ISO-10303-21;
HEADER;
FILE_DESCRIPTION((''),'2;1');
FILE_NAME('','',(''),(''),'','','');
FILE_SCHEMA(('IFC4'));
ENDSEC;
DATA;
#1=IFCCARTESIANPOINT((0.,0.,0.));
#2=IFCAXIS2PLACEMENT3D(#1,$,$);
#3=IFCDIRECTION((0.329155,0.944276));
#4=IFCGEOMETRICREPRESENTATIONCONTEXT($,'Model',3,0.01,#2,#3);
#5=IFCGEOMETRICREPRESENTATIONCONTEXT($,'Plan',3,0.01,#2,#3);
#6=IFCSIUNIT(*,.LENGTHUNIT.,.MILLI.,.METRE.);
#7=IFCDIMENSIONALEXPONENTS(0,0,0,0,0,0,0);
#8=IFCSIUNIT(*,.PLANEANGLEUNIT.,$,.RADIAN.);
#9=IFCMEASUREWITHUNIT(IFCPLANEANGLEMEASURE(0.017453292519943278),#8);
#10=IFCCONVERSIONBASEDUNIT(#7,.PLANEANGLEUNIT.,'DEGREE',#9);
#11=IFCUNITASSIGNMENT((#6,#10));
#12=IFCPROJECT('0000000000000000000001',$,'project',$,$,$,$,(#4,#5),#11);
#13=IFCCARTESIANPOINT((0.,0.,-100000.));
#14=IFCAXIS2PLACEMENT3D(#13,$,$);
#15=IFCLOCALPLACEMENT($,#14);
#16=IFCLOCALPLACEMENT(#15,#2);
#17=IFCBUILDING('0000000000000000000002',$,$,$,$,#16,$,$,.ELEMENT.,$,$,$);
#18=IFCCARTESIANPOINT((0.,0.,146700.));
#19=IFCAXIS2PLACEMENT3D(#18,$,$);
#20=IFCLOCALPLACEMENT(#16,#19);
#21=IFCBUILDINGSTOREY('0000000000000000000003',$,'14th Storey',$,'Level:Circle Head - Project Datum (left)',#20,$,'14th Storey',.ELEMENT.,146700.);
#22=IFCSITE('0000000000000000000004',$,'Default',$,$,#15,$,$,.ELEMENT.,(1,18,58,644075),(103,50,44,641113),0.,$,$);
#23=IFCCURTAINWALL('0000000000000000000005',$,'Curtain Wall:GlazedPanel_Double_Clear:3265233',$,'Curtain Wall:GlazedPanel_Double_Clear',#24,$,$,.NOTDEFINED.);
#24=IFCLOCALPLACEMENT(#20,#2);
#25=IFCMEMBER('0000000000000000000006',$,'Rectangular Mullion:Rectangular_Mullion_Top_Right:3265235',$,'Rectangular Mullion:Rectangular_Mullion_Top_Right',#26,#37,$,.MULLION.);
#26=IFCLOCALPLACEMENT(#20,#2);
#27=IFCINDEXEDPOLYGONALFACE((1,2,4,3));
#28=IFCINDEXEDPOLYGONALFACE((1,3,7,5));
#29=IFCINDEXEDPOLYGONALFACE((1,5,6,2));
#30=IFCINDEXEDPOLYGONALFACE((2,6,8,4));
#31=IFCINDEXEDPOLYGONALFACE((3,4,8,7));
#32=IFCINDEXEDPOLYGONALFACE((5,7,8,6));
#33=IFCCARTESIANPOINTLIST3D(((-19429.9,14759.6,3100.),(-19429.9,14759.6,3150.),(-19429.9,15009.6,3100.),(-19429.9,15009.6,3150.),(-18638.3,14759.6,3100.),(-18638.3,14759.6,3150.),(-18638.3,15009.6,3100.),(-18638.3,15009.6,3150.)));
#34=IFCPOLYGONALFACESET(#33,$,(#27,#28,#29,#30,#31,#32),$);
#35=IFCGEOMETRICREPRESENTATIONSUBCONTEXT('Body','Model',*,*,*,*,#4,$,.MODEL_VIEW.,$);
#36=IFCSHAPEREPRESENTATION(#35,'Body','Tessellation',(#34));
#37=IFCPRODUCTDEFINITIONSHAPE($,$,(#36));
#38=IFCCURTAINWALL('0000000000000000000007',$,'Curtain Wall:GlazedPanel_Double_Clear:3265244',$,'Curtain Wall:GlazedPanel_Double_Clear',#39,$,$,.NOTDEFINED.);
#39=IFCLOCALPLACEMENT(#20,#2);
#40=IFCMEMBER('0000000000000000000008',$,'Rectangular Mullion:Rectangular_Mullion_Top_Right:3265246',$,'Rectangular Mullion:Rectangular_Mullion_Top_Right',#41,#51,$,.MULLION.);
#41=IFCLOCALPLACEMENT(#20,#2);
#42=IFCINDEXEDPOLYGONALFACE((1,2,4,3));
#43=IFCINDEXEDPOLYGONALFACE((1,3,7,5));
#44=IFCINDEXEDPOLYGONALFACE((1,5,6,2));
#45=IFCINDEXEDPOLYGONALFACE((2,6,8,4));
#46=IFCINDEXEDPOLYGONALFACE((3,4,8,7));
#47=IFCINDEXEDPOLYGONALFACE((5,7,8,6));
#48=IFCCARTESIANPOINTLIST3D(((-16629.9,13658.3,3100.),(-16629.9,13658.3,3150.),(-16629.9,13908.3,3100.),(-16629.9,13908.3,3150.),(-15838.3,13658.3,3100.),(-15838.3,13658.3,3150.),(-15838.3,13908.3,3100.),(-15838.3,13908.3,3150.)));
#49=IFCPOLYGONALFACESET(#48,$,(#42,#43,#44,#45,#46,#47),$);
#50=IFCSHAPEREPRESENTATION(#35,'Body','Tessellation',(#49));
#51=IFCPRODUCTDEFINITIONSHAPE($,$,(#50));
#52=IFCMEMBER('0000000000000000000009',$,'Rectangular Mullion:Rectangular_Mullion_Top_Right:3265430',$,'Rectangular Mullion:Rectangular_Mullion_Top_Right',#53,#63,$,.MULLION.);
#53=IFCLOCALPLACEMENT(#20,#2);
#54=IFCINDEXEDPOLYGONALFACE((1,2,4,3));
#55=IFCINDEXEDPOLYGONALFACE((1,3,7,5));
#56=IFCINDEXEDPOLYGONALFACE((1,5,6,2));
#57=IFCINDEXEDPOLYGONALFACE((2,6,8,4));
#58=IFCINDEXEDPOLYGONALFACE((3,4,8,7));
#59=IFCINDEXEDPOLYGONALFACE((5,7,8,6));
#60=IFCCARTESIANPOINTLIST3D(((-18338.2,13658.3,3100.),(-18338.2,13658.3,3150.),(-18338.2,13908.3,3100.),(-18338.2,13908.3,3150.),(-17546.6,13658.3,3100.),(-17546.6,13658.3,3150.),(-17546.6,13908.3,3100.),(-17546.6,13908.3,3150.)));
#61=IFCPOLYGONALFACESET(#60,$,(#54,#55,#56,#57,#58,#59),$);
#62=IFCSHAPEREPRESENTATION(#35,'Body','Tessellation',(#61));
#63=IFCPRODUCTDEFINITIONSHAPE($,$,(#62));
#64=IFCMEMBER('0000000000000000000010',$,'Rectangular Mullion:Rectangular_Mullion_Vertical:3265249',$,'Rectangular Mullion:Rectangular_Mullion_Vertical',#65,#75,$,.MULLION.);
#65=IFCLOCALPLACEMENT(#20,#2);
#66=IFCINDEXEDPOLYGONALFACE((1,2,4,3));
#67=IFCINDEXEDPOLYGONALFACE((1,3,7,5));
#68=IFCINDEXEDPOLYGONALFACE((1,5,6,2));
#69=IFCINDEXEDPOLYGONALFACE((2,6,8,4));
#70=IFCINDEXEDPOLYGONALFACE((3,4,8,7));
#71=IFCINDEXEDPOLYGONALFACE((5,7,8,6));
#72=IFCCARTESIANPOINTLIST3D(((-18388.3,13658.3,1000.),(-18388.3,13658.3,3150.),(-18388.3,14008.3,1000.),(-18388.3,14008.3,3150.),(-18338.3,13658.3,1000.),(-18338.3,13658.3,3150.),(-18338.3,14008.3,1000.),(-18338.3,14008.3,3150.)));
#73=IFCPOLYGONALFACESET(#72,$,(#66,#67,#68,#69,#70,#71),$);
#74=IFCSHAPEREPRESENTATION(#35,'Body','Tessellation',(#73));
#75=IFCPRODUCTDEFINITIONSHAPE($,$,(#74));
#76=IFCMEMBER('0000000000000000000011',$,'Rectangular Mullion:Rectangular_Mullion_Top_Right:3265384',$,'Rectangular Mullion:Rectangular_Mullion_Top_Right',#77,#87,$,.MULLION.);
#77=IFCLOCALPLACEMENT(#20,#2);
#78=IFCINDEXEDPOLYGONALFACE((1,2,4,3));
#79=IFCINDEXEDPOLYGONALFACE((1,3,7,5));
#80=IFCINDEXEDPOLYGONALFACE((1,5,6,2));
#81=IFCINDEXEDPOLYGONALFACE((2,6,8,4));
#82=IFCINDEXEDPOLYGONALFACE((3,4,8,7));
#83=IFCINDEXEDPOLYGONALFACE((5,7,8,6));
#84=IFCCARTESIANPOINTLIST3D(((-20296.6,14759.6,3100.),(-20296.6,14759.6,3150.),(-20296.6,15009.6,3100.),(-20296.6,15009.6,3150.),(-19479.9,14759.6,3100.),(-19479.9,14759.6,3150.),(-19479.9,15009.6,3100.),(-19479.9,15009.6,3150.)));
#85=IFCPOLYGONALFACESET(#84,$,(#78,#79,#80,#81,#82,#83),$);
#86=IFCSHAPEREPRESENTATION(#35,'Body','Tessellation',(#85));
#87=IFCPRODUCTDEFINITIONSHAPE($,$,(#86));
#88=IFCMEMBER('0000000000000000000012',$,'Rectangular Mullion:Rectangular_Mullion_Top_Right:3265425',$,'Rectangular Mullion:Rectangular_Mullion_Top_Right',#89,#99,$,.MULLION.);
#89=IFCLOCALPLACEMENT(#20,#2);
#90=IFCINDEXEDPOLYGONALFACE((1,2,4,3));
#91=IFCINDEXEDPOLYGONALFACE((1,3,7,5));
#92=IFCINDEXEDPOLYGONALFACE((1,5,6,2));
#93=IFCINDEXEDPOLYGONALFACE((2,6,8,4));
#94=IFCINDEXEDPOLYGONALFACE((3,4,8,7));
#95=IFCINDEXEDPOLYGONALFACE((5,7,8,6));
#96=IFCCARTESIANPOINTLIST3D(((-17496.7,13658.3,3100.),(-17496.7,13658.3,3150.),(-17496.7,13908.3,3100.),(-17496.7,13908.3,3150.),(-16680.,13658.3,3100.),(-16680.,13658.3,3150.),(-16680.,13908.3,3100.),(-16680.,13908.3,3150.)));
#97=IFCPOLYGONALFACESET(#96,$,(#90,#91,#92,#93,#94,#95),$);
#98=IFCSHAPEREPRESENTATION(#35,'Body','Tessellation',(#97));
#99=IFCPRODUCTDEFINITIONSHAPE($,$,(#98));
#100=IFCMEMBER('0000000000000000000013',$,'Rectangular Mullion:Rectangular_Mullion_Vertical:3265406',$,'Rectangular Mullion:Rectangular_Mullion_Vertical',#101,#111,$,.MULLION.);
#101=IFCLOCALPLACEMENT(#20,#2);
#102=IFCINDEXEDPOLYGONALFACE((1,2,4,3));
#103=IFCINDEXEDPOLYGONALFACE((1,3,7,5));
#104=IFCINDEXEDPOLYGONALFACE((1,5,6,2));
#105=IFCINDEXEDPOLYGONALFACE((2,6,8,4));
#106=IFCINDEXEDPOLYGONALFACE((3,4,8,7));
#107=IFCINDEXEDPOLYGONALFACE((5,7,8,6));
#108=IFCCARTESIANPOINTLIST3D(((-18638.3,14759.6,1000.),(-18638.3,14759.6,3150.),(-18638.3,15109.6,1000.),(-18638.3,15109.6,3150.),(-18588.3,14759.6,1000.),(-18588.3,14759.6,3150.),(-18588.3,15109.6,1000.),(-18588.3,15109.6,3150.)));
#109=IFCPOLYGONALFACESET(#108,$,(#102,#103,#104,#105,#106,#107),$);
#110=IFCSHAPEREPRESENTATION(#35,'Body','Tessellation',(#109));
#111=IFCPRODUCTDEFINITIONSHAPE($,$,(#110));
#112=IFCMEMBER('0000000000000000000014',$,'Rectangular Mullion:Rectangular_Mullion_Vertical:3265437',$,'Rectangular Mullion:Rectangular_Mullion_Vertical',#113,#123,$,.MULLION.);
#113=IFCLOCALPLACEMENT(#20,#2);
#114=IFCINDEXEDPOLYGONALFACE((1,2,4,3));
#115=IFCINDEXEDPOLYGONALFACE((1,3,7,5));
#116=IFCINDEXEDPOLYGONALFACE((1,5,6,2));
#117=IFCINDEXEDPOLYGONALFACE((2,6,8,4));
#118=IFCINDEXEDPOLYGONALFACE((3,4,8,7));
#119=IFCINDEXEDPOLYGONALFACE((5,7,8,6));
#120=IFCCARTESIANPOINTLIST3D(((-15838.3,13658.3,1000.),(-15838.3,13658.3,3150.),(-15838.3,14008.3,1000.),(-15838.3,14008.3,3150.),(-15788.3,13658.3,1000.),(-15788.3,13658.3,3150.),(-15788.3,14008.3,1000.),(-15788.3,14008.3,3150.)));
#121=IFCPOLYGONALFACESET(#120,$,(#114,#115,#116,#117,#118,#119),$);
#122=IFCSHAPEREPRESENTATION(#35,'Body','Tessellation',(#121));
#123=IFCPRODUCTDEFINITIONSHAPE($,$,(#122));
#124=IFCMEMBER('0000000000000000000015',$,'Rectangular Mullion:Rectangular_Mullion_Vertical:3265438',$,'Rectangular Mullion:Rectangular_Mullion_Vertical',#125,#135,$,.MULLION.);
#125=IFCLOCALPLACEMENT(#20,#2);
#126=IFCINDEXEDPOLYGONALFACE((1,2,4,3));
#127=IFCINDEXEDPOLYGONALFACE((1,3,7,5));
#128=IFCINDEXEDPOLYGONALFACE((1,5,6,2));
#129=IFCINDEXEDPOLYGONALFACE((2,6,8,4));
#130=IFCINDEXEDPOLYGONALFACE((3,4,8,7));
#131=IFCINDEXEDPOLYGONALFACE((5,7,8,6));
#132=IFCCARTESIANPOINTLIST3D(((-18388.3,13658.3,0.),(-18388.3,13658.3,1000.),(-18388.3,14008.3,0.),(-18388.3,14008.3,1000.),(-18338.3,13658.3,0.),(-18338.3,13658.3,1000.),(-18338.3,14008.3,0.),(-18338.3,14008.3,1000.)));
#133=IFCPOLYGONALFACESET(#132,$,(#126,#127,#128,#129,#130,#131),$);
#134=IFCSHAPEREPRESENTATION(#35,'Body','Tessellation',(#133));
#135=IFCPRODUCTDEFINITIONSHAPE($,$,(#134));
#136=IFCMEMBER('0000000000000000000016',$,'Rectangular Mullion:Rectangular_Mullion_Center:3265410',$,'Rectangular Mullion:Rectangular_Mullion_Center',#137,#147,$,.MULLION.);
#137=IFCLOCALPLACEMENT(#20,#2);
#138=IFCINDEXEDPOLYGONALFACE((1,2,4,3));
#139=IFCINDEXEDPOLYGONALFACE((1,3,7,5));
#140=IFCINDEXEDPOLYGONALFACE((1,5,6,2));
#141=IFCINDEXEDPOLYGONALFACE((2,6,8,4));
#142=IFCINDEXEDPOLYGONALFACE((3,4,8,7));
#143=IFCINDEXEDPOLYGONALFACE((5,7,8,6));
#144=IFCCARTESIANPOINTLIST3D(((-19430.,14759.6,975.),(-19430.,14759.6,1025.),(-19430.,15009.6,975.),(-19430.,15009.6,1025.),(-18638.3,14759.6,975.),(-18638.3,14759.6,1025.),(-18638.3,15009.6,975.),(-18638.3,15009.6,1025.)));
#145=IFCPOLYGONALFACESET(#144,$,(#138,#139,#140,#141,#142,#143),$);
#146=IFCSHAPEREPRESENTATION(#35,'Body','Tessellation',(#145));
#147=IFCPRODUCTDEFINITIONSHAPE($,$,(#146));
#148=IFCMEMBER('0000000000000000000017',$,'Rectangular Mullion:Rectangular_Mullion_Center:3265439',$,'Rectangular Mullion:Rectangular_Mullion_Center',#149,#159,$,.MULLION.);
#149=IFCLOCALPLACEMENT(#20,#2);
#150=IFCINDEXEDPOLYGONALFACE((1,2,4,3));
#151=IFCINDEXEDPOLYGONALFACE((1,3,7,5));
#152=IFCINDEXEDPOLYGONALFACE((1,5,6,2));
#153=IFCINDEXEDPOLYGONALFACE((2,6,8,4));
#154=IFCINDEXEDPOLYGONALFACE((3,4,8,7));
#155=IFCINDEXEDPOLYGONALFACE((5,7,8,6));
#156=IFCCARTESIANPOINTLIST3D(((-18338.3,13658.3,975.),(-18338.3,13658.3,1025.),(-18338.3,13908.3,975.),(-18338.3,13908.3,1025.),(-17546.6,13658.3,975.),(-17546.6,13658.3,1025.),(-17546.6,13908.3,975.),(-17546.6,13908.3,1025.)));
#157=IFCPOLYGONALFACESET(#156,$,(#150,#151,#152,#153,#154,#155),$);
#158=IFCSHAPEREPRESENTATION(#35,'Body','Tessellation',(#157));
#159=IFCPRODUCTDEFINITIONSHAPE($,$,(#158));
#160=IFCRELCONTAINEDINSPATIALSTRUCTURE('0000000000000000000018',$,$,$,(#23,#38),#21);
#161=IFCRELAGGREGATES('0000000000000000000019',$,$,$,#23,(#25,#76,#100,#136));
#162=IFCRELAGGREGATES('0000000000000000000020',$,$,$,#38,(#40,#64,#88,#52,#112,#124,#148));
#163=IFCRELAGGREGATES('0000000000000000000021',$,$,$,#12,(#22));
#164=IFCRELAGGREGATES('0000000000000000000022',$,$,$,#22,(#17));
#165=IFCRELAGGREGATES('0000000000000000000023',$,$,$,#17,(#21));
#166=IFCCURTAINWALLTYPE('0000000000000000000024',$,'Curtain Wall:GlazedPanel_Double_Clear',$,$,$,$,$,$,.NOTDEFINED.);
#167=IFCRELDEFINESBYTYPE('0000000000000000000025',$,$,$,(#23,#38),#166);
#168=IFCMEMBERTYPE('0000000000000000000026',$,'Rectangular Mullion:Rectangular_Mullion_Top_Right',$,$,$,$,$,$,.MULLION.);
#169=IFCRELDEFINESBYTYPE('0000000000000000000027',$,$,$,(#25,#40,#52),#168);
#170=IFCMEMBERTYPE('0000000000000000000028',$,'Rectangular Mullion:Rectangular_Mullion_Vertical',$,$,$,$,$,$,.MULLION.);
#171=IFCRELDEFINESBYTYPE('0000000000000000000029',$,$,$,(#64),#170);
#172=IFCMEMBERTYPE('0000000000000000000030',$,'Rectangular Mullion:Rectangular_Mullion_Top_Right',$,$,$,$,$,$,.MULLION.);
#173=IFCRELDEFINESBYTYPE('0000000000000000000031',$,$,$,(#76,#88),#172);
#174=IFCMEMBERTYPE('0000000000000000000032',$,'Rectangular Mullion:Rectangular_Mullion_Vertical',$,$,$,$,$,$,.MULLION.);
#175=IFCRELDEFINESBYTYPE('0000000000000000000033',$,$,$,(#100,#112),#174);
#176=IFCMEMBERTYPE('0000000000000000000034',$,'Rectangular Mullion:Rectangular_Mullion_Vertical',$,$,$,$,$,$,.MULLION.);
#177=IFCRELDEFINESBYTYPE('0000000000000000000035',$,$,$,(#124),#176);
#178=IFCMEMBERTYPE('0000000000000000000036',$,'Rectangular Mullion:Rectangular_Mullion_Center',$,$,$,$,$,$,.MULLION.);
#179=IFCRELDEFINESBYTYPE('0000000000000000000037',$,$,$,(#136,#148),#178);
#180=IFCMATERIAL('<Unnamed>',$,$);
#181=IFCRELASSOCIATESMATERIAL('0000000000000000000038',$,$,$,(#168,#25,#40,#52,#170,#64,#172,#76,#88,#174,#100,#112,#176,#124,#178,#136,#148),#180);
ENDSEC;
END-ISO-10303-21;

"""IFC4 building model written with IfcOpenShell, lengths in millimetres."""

from ifc_helpers import new_model, entity, si_unit, converted_unit, direction, frame, origin, place, context, subcontext, project, spatial, indexed_curve, outline, extrude, source, transform, mapped, material, type_object, type_shapes, element, aggregate, save


model = new_model("IFC4")

# Units and contexts
model_context = context("Model", 3, precision=0.01, world=origin(), true_north=direction((0.329155, 0.944276)))
plan_context = context("Plan", 3, precision=0.01, world=origin(), true_north=direction((0.329155, 0.944276)))
body_context = subcontext(model_context, "Body", "Model", "MODEL_VIEW")
ifc_project = project(units=[si_unit("LENGTHUNIT", "METRE", prefix="MILLI"), converted_unit("PLANEANGLEUNIT", "DEGREE", entity("IfcPlaneAngleMeasure", 0.017453292519943278), si_unit("PLANEANGLEUNIT", "RADIAN"), dimensions=[0, 0, 0, 0, 0, 0, 0])], contexts=[model_context, plan_context])

# Site, building, storey
site_placement = place(None, frame((0.0, 0.0, -100000.0)))
site = spatial("IfcSite", under=ifc_project, at=site_placement, Name="Default", CompositionType="ELEMENT", RefLatitude=(1, 18, 58, 644075), RefLongitude=(103, 50, 44, 641113), RefElevation=0.0)
building_placement = place(site_placement, origin())
building = spatial("IfcBuilding", under=site, at=building_placement, CompositionType="ELEMENT")
storey_placement = place(building_placement, frame((0.0, 0.0, 146700.0)))
storey = spatial("IfcBuildingStorey", under=building, at=storey_placement, Name="14th Storey", ObjectType="Level:Circle Head - Project Datum (left)", LongName="14th Storey", CompositionType="ELEMENT", Elevation=146700.0)

# Curtain wall, member
curtain_wall_type = type_object("IfcCurtainWallType", Name="Curtain Wall:GlazedPanel_Double_Clear", PredefinedType="NOTDEFINED")
curtain_wall_1_placement = place(storey_placement, frame((0.0, 0.0, -146700.0)))
curtain_wall_1 = element("IfcCurtainWall", 1, at=curtain_wall_1_placement, inside=storey, type_object=curtain_wall_type, Name="Curtain Wall:GlazedPanel_Double_Clear:3265233", ObjectType="Curtain Wall:GlazedPanel_Double_Clear", PredefinedType="NOTDEFINED")
ifc_material_1 = material(Name="<Unnamed>")
member_type_1 = type_object("IfcMemberType", Name="Rectangular Mullion:Rectangular_Mullion_Top_Right", PredefinedType="MULLION", material=ifc_material_1)
shared_shape_1 = source(origin(), body_context, "Body", "SweptSolid", [
    extrude(outline(indexed_curve([(-25.0, -125.0), (25.0, -125.0), (25.0, 125.0), (-25.0, 125.0), (-25.0, -125.0)], self_intersect=False)), frame((-25.0, 0.0, -791.6), z_axis=(0.0, 0.0, 1.0), x_axis=(-1.0, 0.0, 0.0)), (0.0, 0.0, 1.0), 791.6),
])
type_shapes(member_type_1, [shared_shape_1])
member_1_placement = place(curtain_wall_1_placement, frame((-18638.3, 14884.6, 149850.0), z_axis=(1.0, 0.0, 0.0), x_axis=(0.0, 0.0, 1.0)))
member_1 = element("IfcMember", 2, at=member_1_placement, type_object=member_type_1, material=ifc_material_1, Name="Rectangular Mullion:Rectangular_Mullion_Top_Right:3265235", ObjectType="Rectangular Mullion:Rectangular_Mullion_Top_Right", PredefinedType="MULLION", context=body_context, shape_type="MappedRepresentation", body=[
    mapped(shared_shape_1, transform((0.0, 0.0, 0.0), scale=1.0)),
])

# Curtain wall, members
curtain_wall_2_placement = place(storey_placement, frame((0.0, 0.0, -146700.0)))
curtain_wall_2 = element("IfcCurtainWall", 3, at=curtain_wall_2_placement, inside=storey, type_object=curtain_wall_type, Name="Curtain Wall:GlazedPanel_Double_Clear:3265244", ObjectType="Curtain Wall:GlazedPanel_Double_Clear", PredefinedType="NOTDEFINED")
member_2_placement = place(curtain_wall_2_placement, frame((-15838.3, 13783.3, 149850.0), z_axis=(1.0, 0.0, 0.0), x_axis=(0.0, 0.0, 1.0)))
member_2 = element("IfcMember", 4, at=member_2_placement, type_object=member_type_1, material=ifc_material_1, Name="Rectangular Mullion:Rectangular_Mullion_Top_Right:3265246", ObjectType="Rectangular Mullion:Rectangular_Mullion_Top_Right", PredefinedType="MULLION", context=body_context, shape_type="MappedRepresentation", body=[
    mapped(shared_shape_1, transform((0.0, 0.0, 0.0), scale=1.0)),
])
member_3_placement = place(curtain_wall_2_placement, frame((-17546.6, 13783.3, 149850.0), z_axis=(1.0, 0.0, 0.0), x_axis=(0.0, 0.0, 1.0)))
member_3 = element("IfcMember", 5, at=member_3_placement, type_object=member_type_1, material=ifc_material_1, Name="Rectangular Mullion:Rectangular_Mullion_Top_Right:3265430", ObjectType="Rectangular Mullion:Rectangular_Mullion_Top_Right", PredefinedType="MULLION", context=body_context, shape_type="MappedRepresentation", body=[
    mapped(shared_shape_1, transform((0.0, 0.0, 0.0), scale=1.0)),
])
member_type_2 = type_object("IfcMemberType", Name="Rectangular Mullion:Rectangular_Mullion_Vertical", PredefinedType="MULLION", material=ifc_material_1)
shared_shape_2 = source(origin(), body_context, "Body", "SweptSolid", [
    extrude(outline(indexed_curve([(-25.0, -175.0), (25.0, -175.0), (25.0, 175.0), (-25.0, 175.0), (-25.0, -175.0)], self_intersect=False)), frame((-25.0, -50.0, -2150.0), z_axis=(0.0, 0.0, 1.0), x_axis=(-1.0, 0.0, 0.0)), (0.0, 0.0, 1.0), 2150.0),
])
type_shapes(member_type_2, [shared_shape_2])
member_4_placement = place(curtain_wall_2_placement, frame((-18388.3, 13783.3, 149850.0), z_axis=(0.0, 0.0, 1.0), x_axis=(-1.0, 0.0, 0.0)))
member_4 = element("IfcMember", 6, at=member_4_placement, type_object=member_type_2, material=ifc_material_1, Name="Rectangular Mullion:Rectangular_Mullion_Vertical:3265249", ObjectType="Rectangular Mullion:Rectangular_Mullion_Vertical", PredefinedType="MULLION", context=body_context, shape_type="MappedRepresentation", body=[
    mapped(shared_shape_2, transform((0.0, 0.0, 0.0), scale=1.0)),
])

# Members
member_type_3 = type_object("IfcMemberType", Name="Rectangular Mullion:Rectangular_Mullion_Top_Right", PredefinedType="MULLION", material=ifc_material_1)
shared_shape_3 = source(origin(), body_context, "Body", "SweptSolid", [
    extrude(outline(indexed_curve([(-25.0, -125.0), (25.0, -125.0), (25.0, 125.0), (-25.0, 125.0), (-25.0, -125.0)], self_intersect=False)), frame((-25.0, 0.0, -816.7), z_axis=(0.0, 0.0, 1.0), x_axis=(-1.0, 0.0, 0.0)), (0.0, 0.0, 1.0), 816.7),
])
type_shapes(member_type_3, [shared_shape_3])
member_5_placement = place(curtain_wall_1_placement, frame((-19479.9, 14884.6, 149850.0), z_axis=(1.0, 0.0, 0.0), x_axis=(0.0, 0.0, 1.0)))
member_5 = element("IfcMember", 7, at=member_5_placement, type_object=member_type_3, material=ifc_material_1, Name="Rectangular Mullion:Rectangular_Mullion_Top_Right:3265384", ObjectType="Rectangular Mullion:Rectangular_Mullion_Top_Right", PredefinedType="MULLION", context=body_context, shape_type="MappedRepresentation", body=[
    mapped(shared_shape_3, transform((0.0, 0.0, 0.0), scale=1.0)),
])
member_6_placement = place(curtain_wall_2_placement, frame((-16680.0, 13783.3, 149850.0), z_axis=(1.0, 0.0, 0.0), x_axis=(0.0, 0.0, 1.0)))
member_6 = element("IfcMember", 8, at=member_6_placement, type_object=member_type_3, material=ifc_material_1, Name="Rectangular Mullion:Rectangular_Mullion_Top_Right:3265425", ObjectType="Rectangular Mullion:Rectangular_Mullion_Top_Right", PredefinedType="MULLION", context=body_context, shape_type="MappedRepresentation", body=[
    mapped(shared_shape_3, transform((0.0, 0.0, 0.0), scale=1.0)),
])
member_type_4 = type_object("IfcMemberType", Name="Rectangular Mullion:Rectangular_Mullion_Vertical", PredefinedType="MULLION", material=ifc_material_1)
shared_shape_4 = source(origin(), body_context, "Body", "SweptSolid", [
    extrude(outline(indexed_curve([(-25.0, -175.0), (25.0, -175.0), (25.0, 175.0), (-25.0, 175.0), (-25.0, -175.0)], self_intersect=False)), frame((-25.0, -50.0, -2150.0), z_axis=(0.0, 0.0, 1.0), x_axis=(-1.0, 0.0, 0.0)), (0.0, 0.0, 1.0), 2150.0),
])
type_shapes(member_type_4, [shared_shape_4])
member_7_placement = place(curtain_wall_1_placement, frame((-18588.3, 14884.6, 147700.0), z_axis=(0.0, 0.0, -1.0), x_axis=(1.0, 0.0, 0.0)))
member_7 = element("IfcMember", 9, at=member_7_placement, type_object=member_type_4, material=ifc_material_1, Name="Rectangular Mullion:Rectangular_Mullion_Vertical:3265406", ObjectType="Rectangular Mullion:Rectangular_Mullion_Vertical", PredefinedType="MULLION", context=body_context, shape_type="MappedRepresentation", body=[
    mapped(shared_shape_4, transform((0.0, 0.0, 0.0), scale=1.0)),
])
member_8_placement = place(curtain_wall_2_placement, frame((-15788.3, 13783.3, 147700.0), z_axis=(0.0, 0.0, -1.0), x_axis=(1.0, 0.0, 0.0)))
member_8 = element("IfcMember", 10, at=member_8_placement, type_object=member_type_4, material=ifc_material_1, Name="Rectangular Mullion:Rectangular_Mullion_Vertical:3265437", ObjectType="Rectangular Mullion:Rectangular_Mullion_Vertical", PredefinedType="MULLION", context=body_context, shape_type="MappedRepresentation", body=[
    mapped(shared_shape_4, transform((0.0, 0.0, 0.0), scale=1.0)),
])
member_type_5 = type_object("IfcMemberType", Name="Rectangular Mullion:Rectangular_Mullion_Vertical", PredefinedType="MULLION", material=ifc_material_1)
shared_shape_5 = source(origin(), body_context, "Body", "SweptSolid", [
    extrude(outline(indexed_curve([(-25.0, -175.0), (25.0, -175.0), (25.0, 175.0), (-25.0, 175.0), (-25.0, -175.0)], self_intersect=False)), frame((-25.0, -50.0, -1000.0), z_axis=(0.0, 0.0, 1.0), x_axis=(-1.0, 0.0, 0.0)), (0.0, 0.0, 1.0), 1000.0),
])
type_shapes(member_type_5, [shared_shape_5])
member_9_placement = place(curtain_wall_2_placement, frame((-18388.3, 13783.3, 147700.0), z_axis=(0.0, 0.0, 1.0), x_axis=(-1.0, 0.0, 0.0)))
member_9 = element("IfcMember", 11, at=member_9_placement, type_object=member_type_5, material=ifc_material_1, Name="Rectangular Mullion:Rectangular_Mullion_Vertical:3265438", ObjectType="Rectangular Mullion:Rectangular_Mullion_Vertical", PredefinedType="MULLION", context=body_context, shape_type="MappedRepresentation", body=[
    mapped(shared_shape_5, transform((0.0, 0.0, 0.0), scale=1.0)),
])
member_type_6 = type_object("IfcMemberType", Name="Rectangular Mullion:Rectangular_Mullion_Center", PredefinedType="MULLION", material=ifc_material_1)
shared_shape_6 = source(origin(), body_context, "Body", "SweptSolid", [
    extrude(outline(indexed_curve([(-25.0, -125.0), (25.0, -125.0), (25.0, 125.0), (-25.0, 125.0), (-25.0, -125.0)], self_intersect=False)), frame((0.0, 0.0, -791.7), z_axis=(0.0, 0.0, 1.0), x_axis=(-1.0, 0.0, 0.0)), (0.0, 0.0, 1.0), 791.7),
])
type_shapes(member_type_6, [shared_shape_6])
member_10_placement = place(curtain_wall_1_placement, frame((-18638.3, 14884.6, 147700.0), z_axis=(1.0, 0.0, 0.0), x_axis=(0.0, 0.0, 1.0)))
member_10 = element("IfcMember", 12, at=member_10_placement, type_object=member_type_6, material=ifc_material_1, Name="Rectangular Mullion:Rectangular_Mullion_Center:3265410", ObjectType="Rectangular Mullion:Rectangular_Mullion_Center", PredefinedType="MULLION", context=body_context, shape_type="MappedRepresentation", body=[
    mapped(shared_shape_6, transform((0.0, 0.0, 0.0), scale=1.0)),
])
member_11_placement = place(curtain_wall_2_placement, frame((-17546.6, 13783.3, 147700.0), z_axis=(1.0, 0.0, 0.0), x_axis=(0.0, 0.0, 1.0)))
member_11 = element("IfcMember", 13, at=member_11_placement, type_object=member_type_6, material=ifc_material_1, Name="Rectangular Mullion:Rectangular_Mullion_Center:3265439", ObjectType="Rectangular Mullion:Rectangular_Mullion_Center", PredefinedType="MULLION", context=body_context, shape_type="MappedRepresentation", body=[
    mapped(shared_shape_6, transform((0.0, 0.0, 0.0), scale=1.0)),
])

aggregate(curtain_wall_1, [member_1, member_5, member_7, member_10])
aggregate(curtain_wall_2, [member_2, member_4, member_6, member_3, member_8, member_9, member_11])

save(model, "model.ifc")
